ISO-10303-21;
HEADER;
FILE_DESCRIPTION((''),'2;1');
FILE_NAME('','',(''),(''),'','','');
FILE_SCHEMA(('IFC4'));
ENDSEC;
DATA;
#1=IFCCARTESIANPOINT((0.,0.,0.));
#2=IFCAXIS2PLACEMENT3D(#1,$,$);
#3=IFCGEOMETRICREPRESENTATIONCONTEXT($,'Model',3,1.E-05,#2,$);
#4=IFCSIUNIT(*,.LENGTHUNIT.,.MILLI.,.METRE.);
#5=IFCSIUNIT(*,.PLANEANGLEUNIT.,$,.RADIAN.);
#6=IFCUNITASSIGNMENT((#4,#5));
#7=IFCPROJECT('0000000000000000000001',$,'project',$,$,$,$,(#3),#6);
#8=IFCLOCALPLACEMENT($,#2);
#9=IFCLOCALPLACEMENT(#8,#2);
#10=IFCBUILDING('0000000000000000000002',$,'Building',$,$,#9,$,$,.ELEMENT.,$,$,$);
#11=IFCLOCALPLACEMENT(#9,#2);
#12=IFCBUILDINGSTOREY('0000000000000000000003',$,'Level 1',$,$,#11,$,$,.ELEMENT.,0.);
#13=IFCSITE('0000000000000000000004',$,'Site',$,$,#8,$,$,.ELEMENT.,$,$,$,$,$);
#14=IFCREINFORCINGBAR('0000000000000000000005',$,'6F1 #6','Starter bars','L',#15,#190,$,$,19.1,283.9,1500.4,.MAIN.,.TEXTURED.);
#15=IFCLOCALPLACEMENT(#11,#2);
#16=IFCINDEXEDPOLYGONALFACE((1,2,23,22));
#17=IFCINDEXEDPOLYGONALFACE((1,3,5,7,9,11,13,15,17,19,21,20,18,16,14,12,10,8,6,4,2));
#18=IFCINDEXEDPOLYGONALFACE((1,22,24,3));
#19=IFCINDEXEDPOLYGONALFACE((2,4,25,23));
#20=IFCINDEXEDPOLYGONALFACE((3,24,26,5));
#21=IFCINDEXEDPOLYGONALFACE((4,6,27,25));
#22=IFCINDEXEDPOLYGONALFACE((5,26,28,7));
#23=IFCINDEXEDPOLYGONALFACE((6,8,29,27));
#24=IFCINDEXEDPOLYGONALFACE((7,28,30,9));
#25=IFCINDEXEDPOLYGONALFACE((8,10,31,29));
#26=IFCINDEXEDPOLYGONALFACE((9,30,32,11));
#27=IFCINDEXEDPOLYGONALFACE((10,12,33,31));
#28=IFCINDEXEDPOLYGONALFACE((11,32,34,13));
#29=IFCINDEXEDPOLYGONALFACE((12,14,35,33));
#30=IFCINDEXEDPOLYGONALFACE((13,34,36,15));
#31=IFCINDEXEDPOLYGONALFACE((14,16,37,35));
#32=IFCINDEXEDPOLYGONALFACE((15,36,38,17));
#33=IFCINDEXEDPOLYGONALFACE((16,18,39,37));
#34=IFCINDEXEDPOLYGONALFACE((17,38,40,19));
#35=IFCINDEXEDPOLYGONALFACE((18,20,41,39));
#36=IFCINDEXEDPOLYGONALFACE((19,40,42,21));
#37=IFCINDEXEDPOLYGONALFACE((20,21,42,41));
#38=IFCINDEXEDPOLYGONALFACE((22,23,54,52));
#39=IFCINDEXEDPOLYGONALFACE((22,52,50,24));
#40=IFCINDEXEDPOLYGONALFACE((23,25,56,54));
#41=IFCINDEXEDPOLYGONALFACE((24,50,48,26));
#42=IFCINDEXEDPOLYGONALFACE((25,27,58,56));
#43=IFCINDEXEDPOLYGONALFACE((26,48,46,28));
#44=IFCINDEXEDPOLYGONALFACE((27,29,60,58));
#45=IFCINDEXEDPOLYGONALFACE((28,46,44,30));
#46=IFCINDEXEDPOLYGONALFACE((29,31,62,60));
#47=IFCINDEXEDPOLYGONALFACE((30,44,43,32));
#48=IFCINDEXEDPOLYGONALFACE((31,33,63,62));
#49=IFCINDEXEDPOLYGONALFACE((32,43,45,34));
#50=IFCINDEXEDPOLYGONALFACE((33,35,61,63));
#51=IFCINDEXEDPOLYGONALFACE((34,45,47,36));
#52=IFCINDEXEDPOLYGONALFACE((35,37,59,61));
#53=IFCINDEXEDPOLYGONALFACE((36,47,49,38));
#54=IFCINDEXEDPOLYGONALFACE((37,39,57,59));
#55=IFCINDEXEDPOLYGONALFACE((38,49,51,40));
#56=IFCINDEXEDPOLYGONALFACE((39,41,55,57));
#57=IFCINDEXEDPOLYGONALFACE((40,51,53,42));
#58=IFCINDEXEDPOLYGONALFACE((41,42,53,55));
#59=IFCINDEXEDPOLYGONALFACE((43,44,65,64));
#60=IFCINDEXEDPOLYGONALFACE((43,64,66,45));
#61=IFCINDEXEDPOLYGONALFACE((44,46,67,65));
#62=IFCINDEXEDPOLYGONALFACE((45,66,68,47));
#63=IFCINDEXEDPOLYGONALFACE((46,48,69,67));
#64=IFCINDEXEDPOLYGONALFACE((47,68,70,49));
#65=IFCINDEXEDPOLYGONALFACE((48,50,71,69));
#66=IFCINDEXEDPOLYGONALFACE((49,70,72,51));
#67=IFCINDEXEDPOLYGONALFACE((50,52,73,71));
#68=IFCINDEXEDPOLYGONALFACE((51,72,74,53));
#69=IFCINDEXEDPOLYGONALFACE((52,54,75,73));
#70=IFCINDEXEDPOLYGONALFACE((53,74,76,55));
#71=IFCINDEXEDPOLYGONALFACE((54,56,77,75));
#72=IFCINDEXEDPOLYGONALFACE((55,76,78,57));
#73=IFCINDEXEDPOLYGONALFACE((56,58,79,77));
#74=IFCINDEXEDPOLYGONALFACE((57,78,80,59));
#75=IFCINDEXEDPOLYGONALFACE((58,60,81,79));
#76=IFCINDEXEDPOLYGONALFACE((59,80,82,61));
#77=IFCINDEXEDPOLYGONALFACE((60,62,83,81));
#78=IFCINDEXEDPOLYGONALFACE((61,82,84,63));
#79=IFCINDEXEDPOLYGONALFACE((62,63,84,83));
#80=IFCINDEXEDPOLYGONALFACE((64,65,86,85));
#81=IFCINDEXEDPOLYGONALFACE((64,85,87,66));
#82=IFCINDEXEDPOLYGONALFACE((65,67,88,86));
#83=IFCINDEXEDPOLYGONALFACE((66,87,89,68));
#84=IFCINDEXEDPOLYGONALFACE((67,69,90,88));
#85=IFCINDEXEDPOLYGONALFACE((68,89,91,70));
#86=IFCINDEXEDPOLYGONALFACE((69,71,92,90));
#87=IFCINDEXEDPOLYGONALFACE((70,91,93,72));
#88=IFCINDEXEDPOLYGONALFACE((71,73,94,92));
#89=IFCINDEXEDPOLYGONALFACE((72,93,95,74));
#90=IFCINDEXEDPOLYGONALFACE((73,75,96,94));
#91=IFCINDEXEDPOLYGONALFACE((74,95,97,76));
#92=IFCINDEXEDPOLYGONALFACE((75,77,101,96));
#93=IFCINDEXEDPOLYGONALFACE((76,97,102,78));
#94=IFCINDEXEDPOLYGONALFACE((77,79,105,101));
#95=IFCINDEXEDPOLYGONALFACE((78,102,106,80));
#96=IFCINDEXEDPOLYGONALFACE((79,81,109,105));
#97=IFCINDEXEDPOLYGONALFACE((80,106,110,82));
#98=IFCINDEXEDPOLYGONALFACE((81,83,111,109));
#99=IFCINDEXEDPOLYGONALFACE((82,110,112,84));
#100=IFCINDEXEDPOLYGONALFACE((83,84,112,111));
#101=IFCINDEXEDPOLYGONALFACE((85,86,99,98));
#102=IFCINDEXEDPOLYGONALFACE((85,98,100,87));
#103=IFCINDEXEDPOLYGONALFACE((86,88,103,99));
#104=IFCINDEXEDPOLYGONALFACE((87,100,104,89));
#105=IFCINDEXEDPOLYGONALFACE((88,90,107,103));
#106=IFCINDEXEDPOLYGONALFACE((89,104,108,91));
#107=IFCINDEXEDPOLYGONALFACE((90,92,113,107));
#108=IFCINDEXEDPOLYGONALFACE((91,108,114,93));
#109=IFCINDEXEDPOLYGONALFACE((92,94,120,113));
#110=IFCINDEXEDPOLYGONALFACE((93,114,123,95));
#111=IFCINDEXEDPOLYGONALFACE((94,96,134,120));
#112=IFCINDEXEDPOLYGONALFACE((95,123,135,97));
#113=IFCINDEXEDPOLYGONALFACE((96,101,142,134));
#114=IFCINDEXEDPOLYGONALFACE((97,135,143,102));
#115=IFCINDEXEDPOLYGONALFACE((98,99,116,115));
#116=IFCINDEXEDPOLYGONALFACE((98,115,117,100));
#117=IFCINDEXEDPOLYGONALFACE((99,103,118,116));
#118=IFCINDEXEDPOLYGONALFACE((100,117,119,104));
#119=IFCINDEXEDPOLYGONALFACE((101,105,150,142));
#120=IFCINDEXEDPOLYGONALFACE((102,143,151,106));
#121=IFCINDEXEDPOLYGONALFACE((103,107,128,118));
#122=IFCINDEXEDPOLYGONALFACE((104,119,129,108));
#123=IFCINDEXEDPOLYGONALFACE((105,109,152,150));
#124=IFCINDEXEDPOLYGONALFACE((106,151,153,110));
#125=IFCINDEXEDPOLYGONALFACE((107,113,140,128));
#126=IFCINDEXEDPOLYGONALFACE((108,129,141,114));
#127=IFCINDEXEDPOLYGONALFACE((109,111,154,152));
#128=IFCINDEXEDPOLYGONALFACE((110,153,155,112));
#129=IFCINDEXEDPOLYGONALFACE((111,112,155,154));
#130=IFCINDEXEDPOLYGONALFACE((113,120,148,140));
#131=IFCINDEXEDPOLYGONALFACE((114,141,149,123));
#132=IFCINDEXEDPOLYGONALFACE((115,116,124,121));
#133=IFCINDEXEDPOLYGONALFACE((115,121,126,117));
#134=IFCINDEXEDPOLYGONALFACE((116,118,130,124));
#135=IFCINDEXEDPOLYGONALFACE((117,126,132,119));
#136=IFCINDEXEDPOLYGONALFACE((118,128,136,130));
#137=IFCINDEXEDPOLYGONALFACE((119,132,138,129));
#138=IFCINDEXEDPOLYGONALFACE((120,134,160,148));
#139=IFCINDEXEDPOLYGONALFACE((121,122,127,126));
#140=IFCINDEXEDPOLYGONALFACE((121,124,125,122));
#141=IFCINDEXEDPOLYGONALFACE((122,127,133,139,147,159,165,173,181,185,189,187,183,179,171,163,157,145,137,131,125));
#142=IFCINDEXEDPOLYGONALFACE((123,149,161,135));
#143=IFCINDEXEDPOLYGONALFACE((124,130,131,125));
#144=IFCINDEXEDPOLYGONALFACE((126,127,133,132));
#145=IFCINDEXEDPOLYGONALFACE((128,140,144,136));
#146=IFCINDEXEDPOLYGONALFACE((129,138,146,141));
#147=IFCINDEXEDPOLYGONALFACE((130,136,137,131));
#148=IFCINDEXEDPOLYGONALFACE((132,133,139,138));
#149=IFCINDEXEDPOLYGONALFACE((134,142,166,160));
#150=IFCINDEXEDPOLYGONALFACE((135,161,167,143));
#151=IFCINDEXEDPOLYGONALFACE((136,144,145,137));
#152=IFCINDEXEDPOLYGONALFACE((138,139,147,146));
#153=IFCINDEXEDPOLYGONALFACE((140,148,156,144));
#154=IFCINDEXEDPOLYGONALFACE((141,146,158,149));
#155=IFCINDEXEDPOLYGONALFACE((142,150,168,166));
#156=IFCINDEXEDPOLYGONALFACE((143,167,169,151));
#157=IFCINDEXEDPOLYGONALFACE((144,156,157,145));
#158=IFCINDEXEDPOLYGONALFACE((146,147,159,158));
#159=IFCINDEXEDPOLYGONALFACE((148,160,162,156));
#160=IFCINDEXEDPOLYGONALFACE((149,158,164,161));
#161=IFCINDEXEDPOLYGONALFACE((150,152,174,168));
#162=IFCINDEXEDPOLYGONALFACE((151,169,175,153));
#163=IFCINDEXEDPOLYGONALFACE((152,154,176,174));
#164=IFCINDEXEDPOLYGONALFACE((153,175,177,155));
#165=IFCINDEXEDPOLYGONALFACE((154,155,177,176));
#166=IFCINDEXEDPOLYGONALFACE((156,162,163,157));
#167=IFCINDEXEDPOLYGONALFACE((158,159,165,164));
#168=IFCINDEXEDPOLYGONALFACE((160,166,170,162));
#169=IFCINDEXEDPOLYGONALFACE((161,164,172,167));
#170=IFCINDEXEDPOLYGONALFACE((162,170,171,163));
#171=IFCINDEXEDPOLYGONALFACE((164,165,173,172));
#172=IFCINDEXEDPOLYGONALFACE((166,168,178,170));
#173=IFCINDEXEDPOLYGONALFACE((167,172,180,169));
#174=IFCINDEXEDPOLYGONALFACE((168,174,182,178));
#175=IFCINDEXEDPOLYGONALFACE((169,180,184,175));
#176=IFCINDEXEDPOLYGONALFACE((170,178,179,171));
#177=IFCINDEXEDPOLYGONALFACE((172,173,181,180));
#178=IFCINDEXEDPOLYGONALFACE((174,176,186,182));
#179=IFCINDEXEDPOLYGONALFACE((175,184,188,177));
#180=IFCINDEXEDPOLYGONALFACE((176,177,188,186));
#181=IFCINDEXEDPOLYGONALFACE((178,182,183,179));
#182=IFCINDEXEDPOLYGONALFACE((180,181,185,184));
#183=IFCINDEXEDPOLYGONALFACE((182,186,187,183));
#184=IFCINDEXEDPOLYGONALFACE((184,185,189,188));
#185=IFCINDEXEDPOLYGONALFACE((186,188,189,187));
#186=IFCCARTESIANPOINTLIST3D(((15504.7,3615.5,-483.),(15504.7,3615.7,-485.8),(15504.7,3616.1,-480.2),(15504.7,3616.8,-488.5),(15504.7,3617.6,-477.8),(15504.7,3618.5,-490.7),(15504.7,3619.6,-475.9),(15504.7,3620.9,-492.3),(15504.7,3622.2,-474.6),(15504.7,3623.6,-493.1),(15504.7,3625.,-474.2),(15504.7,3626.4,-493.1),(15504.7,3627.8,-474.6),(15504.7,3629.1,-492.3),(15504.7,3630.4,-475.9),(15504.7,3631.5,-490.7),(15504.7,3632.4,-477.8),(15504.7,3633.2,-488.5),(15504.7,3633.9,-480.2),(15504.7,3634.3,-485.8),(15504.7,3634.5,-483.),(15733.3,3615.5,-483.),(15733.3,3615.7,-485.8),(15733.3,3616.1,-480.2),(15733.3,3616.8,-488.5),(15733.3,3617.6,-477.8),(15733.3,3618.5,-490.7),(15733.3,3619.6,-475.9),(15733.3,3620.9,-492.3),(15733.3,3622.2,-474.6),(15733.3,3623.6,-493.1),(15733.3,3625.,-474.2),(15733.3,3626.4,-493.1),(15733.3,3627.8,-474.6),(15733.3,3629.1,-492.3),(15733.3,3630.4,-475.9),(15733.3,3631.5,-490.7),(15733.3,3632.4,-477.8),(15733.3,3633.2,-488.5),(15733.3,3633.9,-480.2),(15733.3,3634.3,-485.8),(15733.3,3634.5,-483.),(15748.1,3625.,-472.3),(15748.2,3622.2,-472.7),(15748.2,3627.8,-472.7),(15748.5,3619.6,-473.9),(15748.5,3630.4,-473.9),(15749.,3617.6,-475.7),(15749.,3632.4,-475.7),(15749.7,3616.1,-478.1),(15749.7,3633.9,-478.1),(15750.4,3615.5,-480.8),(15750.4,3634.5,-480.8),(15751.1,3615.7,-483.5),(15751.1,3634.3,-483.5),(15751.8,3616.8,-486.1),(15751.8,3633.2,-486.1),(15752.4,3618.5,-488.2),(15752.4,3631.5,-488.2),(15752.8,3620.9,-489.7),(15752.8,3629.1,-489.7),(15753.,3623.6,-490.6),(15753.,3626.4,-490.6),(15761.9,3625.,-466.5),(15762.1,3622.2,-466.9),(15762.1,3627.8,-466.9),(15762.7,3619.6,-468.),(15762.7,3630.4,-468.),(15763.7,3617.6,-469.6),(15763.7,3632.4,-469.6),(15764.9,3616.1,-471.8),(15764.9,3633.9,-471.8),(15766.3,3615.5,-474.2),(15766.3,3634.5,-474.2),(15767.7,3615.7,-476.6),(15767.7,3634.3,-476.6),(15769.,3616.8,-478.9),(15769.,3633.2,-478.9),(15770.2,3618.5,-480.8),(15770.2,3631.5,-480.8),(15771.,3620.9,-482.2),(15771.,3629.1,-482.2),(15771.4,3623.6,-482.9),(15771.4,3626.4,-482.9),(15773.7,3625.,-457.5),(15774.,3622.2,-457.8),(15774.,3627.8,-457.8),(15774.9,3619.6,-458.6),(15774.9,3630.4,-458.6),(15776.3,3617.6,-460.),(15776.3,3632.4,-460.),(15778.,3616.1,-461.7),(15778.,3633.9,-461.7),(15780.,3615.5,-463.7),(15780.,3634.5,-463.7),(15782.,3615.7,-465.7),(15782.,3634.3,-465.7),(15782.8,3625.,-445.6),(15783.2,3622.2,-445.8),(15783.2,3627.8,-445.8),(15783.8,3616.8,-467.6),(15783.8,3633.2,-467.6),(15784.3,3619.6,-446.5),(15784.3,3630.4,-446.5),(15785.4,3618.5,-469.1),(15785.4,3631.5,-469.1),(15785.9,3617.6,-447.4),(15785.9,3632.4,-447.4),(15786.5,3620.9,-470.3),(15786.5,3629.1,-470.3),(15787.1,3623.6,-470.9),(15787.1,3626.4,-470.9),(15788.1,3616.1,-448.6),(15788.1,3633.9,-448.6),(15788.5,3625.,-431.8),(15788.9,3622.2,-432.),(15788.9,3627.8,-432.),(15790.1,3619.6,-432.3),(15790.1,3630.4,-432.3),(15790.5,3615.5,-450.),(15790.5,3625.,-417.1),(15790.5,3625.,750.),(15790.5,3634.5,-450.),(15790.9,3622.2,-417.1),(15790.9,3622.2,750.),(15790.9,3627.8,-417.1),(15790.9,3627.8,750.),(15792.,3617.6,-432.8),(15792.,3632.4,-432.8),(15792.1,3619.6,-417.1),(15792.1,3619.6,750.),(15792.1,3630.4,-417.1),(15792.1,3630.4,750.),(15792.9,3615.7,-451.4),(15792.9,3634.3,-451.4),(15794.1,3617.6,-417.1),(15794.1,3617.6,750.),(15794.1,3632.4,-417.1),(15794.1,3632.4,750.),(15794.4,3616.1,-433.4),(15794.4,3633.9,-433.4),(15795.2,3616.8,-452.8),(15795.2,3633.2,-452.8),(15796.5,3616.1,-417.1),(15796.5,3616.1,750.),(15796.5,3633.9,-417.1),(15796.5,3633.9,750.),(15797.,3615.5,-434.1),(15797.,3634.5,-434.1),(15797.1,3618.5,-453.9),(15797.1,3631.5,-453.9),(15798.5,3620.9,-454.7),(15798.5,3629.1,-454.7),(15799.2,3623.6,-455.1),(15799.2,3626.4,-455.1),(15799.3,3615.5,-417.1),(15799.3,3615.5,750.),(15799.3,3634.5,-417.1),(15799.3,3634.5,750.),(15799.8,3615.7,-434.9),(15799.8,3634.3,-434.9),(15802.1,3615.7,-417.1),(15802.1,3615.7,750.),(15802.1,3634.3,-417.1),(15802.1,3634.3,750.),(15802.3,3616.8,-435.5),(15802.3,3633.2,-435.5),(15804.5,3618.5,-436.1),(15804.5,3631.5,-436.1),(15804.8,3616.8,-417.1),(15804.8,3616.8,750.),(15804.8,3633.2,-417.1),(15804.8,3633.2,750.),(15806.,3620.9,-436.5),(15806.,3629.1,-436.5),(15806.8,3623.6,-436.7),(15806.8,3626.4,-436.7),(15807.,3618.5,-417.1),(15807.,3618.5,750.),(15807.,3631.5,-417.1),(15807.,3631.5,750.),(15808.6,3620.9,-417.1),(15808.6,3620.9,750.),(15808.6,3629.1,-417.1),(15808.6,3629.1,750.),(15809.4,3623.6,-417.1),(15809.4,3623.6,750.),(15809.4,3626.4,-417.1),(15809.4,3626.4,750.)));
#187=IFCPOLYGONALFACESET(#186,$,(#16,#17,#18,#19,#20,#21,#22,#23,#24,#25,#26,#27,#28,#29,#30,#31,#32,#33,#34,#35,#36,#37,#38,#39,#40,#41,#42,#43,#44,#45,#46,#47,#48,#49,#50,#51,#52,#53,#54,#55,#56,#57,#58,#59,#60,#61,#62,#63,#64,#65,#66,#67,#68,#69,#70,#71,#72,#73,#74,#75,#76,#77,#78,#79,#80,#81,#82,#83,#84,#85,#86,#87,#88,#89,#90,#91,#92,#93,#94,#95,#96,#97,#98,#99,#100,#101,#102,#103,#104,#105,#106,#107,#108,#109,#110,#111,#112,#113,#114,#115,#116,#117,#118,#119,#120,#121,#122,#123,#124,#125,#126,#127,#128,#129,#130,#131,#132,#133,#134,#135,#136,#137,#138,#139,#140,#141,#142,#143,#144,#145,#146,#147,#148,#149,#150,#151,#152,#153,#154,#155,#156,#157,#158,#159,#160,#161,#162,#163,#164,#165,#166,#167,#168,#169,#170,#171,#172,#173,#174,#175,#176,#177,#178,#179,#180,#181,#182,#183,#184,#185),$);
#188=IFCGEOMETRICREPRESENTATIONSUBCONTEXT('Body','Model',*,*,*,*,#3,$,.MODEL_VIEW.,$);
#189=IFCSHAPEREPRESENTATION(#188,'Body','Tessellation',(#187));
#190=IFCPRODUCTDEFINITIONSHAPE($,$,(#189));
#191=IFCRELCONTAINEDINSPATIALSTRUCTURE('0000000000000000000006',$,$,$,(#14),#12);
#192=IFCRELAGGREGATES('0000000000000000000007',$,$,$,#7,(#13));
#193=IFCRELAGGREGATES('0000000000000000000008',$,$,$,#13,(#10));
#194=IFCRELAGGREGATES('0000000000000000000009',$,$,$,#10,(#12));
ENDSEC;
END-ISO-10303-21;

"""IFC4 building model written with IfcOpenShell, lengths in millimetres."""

from ifc_helpers import new_model, entity, si_unit, origin, place, context, subcontext, project, spatial, element, save


model = new_model("IFC4")

# Units and contexts
model_context = context("Model", 3, precision=1e-05, world=origin())
body_context = subcontext(model_context, "Body", "Model", "MODEL_VIEW")
ifc_project = project(units=[si_unit("LENGTHUNIT", "METRE", prefix="MILLI"), si_unit("PLANEANGLEUNIT", "RADIAN")], contexts=[model_context])

# Site, building, storey
site_placement = place(None, origin())
site = spatial("IfcSite", under=ifc_project, at=site_placement, Name="Site", CompositionType="ELEMENT")
building_placement = place(site_placement, origin())
building = spatial("IfcBuilding", under=site, at=building_placement, Name="Building", CompositionType="ELEMENT")
storey_placement = place(building_placement, origin())
storey = spatial("IfcBuildingStorey", under=building, at=storey_placement, Name="Level 1", CompositionType="ELEMENT", Elevation=0.0)

# Reinforcing bar
reinforcing_bar_1_placement = place(storey_placement, origin())
element("IfcReinforcingBar", 1, at=reinforcing_bar_1_placement, inside=storey, Name="6F1 #6", Description="Starter bars", ObjectType="L", BarLength=1500.4, BarSurface="TEXTURED", CrossSectionArea=283.9, NominalDiameter=19.1, PredefinedType="MAIN", context=body_context, shape_type="AdvancedSweptSolid", body=[
    entity("IfcSweptDiskSolid", entity("IfcIndexedPolyCurve", entity("IfcCartesianPointList3D", [[15800.0, 3625.0, 750.0], [15800.0, 3625.0, -417.1], [15780.5, 3625.0, -464.2], [15733.3, 3625.0, -483.7], [15504.7, 3625.0, -483.7]]), [entity("IfcLineIndex", [1, 2]), entity("IfcArcIndex", [2, 3, 4]), entity("IfcLineIndex", [4, 5])], False), 9.5),
])

save(model, "model.ifc")
